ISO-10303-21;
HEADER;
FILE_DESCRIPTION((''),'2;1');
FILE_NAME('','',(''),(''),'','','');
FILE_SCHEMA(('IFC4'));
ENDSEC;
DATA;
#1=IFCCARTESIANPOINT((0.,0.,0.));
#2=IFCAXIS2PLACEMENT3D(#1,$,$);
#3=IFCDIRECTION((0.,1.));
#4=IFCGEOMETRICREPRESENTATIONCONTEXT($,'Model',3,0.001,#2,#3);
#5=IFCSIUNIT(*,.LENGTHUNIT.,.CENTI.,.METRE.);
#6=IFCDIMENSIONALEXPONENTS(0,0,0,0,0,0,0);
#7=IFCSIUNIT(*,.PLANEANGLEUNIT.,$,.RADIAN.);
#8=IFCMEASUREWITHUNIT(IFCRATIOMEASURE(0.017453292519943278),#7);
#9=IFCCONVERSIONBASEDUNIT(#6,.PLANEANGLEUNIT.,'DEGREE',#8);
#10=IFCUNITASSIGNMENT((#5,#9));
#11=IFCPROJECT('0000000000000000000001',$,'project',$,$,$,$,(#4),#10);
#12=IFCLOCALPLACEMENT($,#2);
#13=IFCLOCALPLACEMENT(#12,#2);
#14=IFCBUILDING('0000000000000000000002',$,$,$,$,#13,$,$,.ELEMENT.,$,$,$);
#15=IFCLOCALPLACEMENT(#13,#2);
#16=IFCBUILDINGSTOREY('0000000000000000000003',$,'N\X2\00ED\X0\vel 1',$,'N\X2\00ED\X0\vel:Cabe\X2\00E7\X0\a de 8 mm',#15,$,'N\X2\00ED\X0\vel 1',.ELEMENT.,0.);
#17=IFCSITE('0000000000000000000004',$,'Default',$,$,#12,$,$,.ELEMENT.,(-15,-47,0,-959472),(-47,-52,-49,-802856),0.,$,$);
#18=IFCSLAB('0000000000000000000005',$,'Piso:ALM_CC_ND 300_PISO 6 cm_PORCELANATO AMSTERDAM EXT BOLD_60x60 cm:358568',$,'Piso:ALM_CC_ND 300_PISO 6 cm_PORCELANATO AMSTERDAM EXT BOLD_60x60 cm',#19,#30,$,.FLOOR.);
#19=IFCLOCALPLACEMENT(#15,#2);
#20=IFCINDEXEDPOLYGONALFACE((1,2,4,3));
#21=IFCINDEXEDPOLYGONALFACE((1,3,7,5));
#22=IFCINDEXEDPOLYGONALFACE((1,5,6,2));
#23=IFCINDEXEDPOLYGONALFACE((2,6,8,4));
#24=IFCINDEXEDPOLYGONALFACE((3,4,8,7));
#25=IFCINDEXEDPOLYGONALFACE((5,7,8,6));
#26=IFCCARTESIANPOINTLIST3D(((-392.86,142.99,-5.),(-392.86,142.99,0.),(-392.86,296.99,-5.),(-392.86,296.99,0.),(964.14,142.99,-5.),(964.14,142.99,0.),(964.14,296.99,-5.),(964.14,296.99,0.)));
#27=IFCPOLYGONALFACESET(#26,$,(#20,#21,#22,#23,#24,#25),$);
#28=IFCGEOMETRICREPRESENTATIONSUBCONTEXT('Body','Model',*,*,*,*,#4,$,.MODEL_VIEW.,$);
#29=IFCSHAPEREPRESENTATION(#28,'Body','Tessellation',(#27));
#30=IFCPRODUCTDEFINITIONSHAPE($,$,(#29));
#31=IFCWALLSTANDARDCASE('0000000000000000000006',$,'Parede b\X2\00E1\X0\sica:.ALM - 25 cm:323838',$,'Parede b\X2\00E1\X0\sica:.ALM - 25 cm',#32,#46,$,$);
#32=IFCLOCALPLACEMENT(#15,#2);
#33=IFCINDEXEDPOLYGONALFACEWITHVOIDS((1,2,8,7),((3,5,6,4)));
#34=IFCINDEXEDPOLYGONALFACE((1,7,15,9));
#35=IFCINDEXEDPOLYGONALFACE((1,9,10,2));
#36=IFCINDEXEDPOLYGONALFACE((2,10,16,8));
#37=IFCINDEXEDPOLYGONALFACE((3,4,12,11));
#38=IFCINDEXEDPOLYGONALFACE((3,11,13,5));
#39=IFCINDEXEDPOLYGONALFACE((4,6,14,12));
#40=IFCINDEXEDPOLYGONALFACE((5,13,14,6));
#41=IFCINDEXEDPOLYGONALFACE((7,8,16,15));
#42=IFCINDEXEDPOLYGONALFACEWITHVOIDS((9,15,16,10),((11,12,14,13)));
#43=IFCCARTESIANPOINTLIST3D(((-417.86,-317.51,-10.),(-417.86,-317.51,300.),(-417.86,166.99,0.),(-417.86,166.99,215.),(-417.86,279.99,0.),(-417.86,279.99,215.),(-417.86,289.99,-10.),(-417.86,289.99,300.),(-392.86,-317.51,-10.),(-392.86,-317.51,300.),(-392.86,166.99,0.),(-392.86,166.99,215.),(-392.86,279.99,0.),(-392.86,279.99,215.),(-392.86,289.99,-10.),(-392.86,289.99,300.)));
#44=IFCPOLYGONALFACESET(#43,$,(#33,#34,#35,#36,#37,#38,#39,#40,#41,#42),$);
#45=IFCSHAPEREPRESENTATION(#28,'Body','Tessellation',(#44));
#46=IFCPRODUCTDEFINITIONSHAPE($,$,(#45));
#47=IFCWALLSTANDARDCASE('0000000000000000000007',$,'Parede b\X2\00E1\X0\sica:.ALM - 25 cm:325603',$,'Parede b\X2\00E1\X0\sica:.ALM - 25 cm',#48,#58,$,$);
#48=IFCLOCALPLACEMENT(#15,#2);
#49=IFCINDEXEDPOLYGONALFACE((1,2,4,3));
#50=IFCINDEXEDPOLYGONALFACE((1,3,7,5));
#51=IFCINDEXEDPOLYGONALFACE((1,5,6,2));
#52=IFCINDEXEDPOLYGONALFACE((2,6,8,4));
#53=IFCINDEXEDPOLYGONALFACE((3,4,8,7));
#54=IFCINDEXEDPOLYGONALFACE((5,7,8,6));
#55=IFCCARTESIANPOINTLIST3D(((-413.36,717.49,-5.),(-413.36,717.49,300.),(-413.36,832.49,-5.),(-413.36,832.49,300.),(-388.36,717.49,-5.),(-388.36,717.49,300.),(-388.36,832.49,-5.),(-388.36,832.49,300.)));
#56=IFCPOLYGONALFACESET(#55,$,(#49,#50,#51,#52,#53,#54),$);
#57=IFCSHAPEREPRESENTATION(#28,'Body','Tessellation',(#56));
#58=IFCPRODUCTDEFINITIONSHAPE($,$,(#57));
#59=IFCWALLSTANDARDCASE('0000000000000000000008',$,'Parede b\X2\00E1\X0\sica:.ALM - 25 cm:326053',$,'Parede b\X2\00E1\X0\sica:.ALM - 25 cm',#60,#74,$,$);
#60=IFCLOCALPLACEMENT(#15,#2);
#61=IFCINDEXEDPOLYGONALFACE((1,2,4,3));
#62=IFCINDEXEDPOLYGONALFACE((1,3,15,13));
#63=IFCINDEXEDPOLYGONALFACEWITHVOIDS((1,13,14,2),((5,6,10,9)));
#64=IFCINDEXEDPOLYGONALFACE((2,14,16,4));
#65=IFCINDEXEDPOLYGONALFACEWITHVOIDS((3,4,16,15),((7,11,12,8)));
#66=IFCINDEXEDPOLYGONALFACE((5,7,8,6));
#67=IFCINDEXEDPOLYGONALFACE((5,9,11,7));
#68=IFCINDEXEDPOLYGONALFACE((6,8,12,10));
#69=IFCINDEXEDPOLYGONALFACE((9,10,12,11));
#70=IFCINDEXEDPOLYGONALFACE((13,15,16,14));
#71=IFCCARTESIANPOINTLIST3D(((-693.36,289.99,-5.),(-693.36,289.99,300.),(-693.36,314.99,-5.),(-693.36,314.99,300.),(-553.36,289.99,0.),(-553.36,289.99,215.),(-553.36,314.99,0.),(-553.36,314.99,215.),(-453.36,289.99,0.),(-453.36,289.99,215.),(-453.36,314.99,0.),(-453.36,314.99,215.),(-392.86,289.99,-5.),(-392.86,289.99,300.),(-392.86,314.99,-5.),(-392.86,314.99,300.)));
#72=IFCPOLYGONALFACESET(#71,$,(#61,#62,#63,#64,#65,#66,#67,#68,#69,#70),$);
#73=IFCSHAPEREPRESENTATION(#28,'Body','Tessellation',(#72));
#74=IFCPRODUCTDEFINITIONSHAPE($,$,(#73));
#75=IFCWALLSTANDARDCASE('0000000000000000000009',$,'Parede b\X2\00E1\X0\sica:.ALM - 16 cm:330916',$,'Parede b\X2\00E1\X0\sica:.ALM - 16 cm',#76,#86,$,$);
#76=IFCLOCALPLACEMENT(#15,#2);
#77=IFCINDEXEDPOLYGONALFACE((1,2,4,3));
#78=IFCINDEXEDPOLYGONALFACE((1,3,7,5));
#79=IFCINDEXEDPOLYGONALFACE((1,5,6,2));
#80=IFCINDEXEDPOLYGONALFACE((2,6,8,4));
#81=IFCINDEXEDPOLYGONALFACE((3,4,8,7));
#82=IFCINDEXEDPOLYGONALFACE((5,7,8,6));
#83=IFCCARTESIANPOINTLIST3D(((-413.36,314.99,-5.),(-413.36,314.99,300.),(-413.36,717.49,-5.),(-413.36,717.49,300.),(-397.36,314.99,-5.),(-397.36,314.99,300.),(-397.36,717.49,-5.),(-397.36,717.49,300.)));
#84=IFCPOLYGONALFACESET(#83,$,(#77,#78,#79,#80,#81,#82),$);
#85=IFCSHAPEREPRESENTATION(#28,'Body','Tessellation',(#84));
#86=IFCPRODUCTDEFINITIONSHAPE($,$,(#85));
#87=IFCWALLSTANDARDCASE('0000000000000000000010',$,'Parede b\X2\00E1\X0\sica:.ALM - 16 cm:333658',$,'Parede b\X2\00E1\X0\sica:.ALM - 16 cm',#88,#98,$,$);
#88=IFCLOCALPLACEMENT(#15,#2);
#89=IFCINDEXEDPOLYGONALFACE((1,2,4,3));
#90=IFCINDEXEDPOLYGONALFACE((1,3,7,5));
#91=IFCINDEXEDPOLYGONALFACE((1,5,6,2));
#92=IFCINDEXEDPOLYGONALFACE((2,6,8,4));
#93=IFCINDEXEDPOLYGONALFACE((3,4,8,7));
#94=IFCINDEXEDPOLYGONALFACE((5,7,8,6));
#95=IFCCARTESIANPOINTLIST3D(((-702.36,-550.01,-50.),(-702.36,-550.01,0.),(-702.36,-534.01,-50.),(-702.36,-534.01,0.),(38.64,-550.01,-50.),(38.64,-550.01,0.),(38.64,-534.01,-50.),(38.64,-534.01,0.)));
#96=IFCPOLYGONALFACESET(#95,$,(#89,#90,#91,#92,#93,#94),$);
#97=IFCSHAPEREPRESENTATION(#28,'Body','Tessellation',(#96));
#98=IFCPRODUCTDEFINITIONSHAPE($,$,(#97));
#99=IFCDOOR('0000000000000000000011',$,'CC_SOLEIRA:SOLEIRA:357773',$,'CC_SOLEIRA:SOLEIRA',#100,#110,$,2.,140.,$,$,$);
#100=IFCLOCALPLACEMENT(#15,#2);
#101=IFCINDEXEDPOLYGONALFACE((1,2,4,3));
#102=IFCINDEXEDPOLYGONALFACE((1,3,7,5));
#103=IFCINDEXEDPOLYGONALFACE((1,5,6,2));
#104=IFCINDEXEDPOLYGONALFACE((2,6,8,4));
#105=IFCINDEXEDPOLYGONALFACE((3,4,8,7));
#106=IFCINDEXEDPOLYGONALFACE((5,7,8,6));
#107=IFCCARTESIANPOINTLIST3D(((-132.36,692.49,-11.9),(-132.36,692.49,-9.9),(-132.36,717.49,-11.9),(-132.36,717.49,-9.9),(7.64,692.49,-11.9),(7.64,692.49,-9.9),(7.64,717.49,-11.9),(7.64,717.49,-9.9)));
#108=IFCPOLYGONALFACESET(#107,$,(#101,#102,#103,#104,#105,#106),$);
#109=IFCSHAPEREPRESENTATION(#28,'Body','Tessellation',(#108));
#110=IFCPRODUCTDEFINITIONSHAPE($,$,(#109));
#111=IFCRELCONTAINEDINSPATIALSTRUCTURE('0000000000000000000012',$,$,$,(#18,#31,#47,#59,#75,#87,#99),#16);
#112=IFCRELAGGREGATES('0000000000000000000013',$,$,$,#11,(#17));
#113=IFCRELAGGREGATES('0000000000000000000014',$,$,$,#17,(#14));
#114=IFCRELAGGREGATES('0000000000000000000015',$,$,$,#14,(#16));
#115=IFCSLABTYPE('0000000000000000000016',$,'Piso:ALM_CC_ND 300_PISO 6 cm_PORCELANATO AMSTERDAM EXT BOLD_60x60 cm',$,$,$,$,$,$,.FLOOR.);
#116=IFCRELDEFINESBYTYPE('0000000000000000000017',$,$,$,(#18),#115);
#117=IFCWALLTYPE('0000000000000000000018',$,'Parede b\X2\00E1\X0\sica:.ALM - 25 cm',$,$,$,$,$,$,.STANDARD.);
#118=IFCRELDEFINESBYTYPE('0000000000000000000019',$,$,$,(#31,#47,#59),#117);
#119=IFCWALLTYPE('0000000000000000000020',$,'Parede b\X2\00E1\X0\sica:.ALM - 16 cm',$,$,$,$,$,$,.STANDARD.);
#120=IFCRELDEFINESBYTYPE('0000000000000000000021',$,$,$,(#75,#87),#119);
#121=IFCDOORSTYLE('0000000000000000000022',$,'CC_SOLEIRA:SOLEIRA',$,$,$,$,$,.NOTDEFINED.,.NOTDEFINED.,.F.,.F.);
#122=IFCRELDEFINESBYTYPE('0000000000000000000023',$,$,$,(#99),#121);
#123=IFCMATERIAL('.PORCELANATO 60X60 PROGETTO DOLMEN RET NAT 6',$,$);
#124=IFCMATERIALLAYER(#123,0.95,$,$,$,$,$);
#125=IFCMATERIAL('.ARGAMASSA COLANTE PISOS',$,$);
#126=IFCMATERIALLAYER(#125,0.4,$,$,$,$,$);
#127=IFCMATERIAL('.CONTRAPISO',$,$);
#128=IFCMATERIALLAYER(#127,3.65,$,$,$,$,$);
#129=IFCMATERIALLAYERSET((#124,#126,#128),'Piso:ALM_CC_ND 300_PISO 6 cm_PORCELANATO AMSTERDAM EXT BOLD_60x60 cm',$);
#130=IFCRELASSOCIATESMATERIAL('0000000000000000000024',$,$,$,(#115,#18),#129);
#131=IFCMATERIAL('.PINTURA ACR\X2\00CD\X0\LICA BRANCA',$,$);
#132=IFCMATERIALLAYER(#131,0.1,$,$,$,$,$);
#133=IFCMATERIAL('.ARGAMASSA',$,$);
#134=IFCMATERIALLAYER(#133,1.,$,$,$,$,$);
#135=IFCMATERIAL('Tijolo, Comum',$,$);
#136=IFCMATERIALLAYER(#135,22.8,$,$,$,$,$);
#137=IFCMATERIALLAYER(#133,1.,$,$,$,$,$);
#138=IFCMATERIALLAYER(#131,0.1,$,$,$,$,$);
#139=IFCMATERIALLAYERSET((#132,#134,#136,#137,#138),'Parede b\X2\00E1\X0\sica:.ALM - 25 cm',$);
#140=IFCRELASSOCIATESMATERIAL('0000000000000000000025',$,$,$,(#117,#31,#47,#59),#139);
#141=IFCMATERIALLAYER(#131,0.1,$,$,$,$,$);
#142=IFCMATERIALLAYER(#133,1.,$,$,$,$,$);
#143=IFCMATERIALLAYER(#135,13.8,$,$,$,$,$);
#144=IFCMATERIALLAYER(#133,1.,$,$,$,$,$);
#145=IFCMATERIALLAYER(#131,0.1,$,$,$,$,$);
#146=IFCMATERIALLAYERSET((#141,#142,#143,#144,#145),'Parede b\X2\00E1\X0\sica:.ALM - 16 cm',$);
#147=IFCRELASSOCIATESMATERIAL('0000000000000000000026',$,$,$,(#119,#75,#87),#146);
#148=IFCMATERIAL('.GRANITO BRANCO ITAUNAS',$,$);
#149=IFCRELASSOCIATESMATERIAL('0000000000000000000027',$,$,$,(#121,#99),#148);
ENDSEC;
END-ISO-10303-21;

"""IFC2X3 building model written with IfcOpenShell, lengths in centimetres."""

from ifc_helpers import new_model, entity, si_unit, converted_unit, direction, frame, frame_2d, origin, origin_2d_with_axis, place, context, subcontext, project, spatial, rectangle, extrude, source, transform, mapped, material, layer, layer_set, layer_usage, type_object, type_shapes, element, save


model = new_model("IFC2X3")

# Units and contexts
model_context = context("Model", 3, precision=0.001, world=origin(), true_north=direction((0.0, 1.0)))
body_context = subcontext(model_context, "Body", "Model", "MODEL_VIEW")
ifc_project = project(units=[si_unit("LENGTHUNIT", "METRE", prefix="CENTI"), converted_unit("PLANEANGLEUNIT", "DEGREE", entity("IfcRatioMeasure", 0.017453292519943278), si_unit("PLANEANGLEUNIT", "RADIAN"), dimensions=[0, 0, 0, 0, 0, 0, 0])], contexts=[model_context])

# Site, building, storey
site_placement = place(None, origin())
site = spatial("IfcSite", under=ifc_project, at=site_placement, Name="Default", CompositionType="ELEMENT", RefLatitude=(-15, -47, 0, -959472), RefLongitude=(-47, -52, -49, -802856), RefElevation=0.0)
building_placement = place(site_placement, origin())
building = spatial("IfcBuilding", under=site, at=building_placement, CompositionType="ELEMENT")
storey_placement = place(building_placement, origin())
storey = spatial("IfcBuildingStorey", under=building, at=storey_placement, Name="Nível 1", ObjectType="Nível:Cabeça de 8 mm", LongName="Nível 1", CompositionType="ELEMENT", Elevation=0.0)

# Slab
ifc_material_1 = material(Name=".PORCELANATO 60X60 PROGETTO DOLMEN RET NAT 6")
ifc_layer_1 = layer(ifc_material_1, 0.95)
ifc_material_2 = material(Name=".ARGAMASSA COLANTE PISOS")
ifc_layer_2 = layer(ifc_material_2, 0.4)
ifc_material_3 = material(Name=".CONTRAPISO")
ifc_layer_3 = layer(ifc_material_3, 3.65)
ifc_layer_set_1 = layer_set([ifc_layer_1, ifc_layer_2, ifc_layer_3], Name="Piso:ALM_CC_ND 300_PISO 6 cm_PORCELANATO AMSTERDAM EXT BOLD_60x60 cm")
ifc_layer_usage_1 = layer_usage(ifc_layer_set_1, "AXIS3", "POSITIVE", 0.0)
slab_type_1 = type_object("IfcSlabType", Name="Piso:ALM_CC_ND 300_PISO 6 cm_PORCELANATO AMSTERDAM EXT BOLD_60x60 cm", PredefinedType="FLOOR", material=ifc_layer_set_1)
slab_1_placement = place(storey_placement, origin())
element("IfcSlab", 1, at=slab_1_placement, inside=storey, type_object=slab_type_1, material=ifc_layer_usage_1, Name="Piso:ALM_CC_ND 300_PISO 6 cm_PORCELANATO AMSTERDAM EXT BOLD_60x60 cm:358568", ObjectType="Piso:ALM_CC_ND 300_PISO 6 cm_PORCELANATO AMSTERDAM EXT BOLD_60x60 cm", PredefinedType="FLOOR", context=body_context, shape_type="SweptSolid", body=[
    extrude(rectangle(XDim=154.0, YDim=1357.0, at=frame_2d((0.0, 0.0), x_axis=(1.0, 0.0))), frame((285.64, 219.99, 0.0), z_axis=(0.0, 0.0, -1.0), x_axis=(0.0, 1.0, 0.0)), (0.0, 0.0, 1.0), 5.0),
])

# Wall, opening
ifc_material_4 = material(Name=".PINTURA ACRÍLICA BRANCA")
ifc_layer_4 = layer(ifc_material_4, 0.1)
ifc_material_5 = material(Name=".ARGAMASSA")
ifc_layer_5 = layer(ifc_material_5, 1.0)
ifc_material_6 = material(Name="Tijolo, Comum")
ifc_layer_6 = layer(ifc_material_6, 22.8)
ifc_layer_7 = layer(ifc_material_5, 1.0)
ifc_layer_8 = layer(ifc_material_4, 0.1)
ifc_layer_set_2 = layer_set([ifc_layer_4, ifc_layer_5, ifc_layer_6, ifc_layer_7, ifc_layer_8], Name="Parede básica:.ALM - 25 cm")
ifc_layer_usage_2 = layer_usage(ifc_layer_set_2, "AXIS2", "NEGATIVE", 12.5)
wall_type_1 = type_object("IfcWallType", Name="Parede básica:.ALM - 25 cm", PredefinedType="STANDARD", material=ifc_layer_set_2)
wall_1_placement = place(storey_placement, frame((-405.36, -317.51, -10.0), z_axis=(0.0, 0.0, 1.0), x_axis=(0.0, 1.0, 0.0)))
wall_1 = element("IfcWallStandardCase", 2, at=wall_1_placement, inside=storey, type_object=wall_type_1, material=ifc_layer_usage_2, Name="Parede básica:.ALM - 25 cm:323838", ObjectType="Parede básica:.ALM - 25 cm", context=body_context, shape_type="SweptSolid", body=[
    extrude(rectangle(XDim=607.5, YDim=25.0, at=frame_2d((303.75, 0.0), x_axis=(-1.0, 0.0))), origin(), (0.0, 0.0, 1.0), 310.0),
])
opening_1_placement = place(wall_1_placement, frame((484.5, -12.5, 10.0)))
element("IfcOpeningElement", 3, at=opening_1_placement, cuts=wall_1, ObjectType="Opening", context=body_context, shape_type="SweptSolid", body=[
    extrude(rectangle(XDim=215.0, YDim=113.0, at=frame_2d((107.5, 56.5), x_axis=(1.0, 0.0))), frame((0.0, 0.0, 0.0), z_axis=(0.0, 1.0, 0.0), x_axis=(0.0, 0.0, 1.0)), (0.0, 0.0, 1.0), 25.0),
])

# Wall
wall_2_placement = place(storey_placement, frame((-400.86, 717.49, -5.0), z_axis=(0.0, 0.0, 1.0), x_axis=(0.0, 1.0, 0.0)))
element("IfcWallStandardCase", 4, at=wall_2_placement, inside=storey, type_object=wall_type_1, material=ifc_layer_usage_2, Name="Parede básica:.ALM - 25 cm:325603", ObjectType="Parede básica:.ALM - 25 cm", context=body_context, shape_type="SweptSolid", body=[
    extrude(rectangle(XDim=115.0, YDim=25.0, at=frame_2d((57.5, 0.0), x_axis=(-1.0, 0.0))), origin(), (0.0, 0.0, 1.0), 305.0),
])

# Wall, opening
wall_3_placement = place(storey_placement, frame((-392.86, 302.49, -5.0), z_axis=(0.0, 0.0, 1.0), x_axis=(-1.0, 0.0, 0.0)))
wall_3 = element("IfcWallStandardCase", 5, at=wall_3_placement, inside=storey, type_object=wall_type_1, material=ifc_layer_usage_2, Name="Parede básica:.ALM - 25 cm:326053", ObjectType="Parede básica:.ALM - 25 cm", context=body_context, shape_type="SweptSolid", body=[
    extrude(rectangle(XDim=300.5, YDim=25.0, at=frame_2d((150.25, 0.0), x_axis=(-1.0, 0.0))), origin(), (0.0, 0.0, 1.0), 305.0),
])
opening_2_placement = place(wall_3_placement, frame((60.5, -12.5, 5.0)))
element("IfcOpeningElement", 6, at=opening_2_placement, cuts=wall_3, ObjectType="Opening", context=body_context, shape_type="SweptSolid", body=[
    extrude(rectangle(XDim=215.0, YDim=100.0, at=frame_2d((107.5, 50.0), x_axis=(1.0, 0.0))), frame((0.0, 0.0, 0.0), z_axis=(0.0, 1.0, 0.0), x_axis=(0.0, 0.0, 1.0)), (0.0, 0.0, 1.0), 25.0),
])

# Walls
ifc_layer_9 = layer(ifc_material_4, 0.1)
ifc_layer_10 = layer(ifc_material_5, 1.0)
ifc_layer_11 = layer(ifc_material_6, 13.8)
ifc_layer_12 = layer(ifc_material_5, 1.0)
ifc_layer_13 = layer(ifc_material_4, 0.1)
ifc_layer_set_3 = layer_set([ifc_layer_9, ifc_layer_10, ifc_layer_11, ifc_layer_12, ifc_layer_13], Name="Parede básica:.ALM - 16 cm")
ifc_layer_usage_3 = layer_usage(ifc_layer_set_3, "AXIS2", "NEGATIVE", 8.0)
wall_type_2 = type_object("IfcWallType", Name="Parede básica:.ALM - 16 cm", PredefinedType="STANDARD", material=ifc_layer_set_3)
wall_4_placement = place(storey_placement, frame((-405.36, 314.99, -5.0), z_axis=(0.0, 0.0, 1.0), x_axis=(0.0, 1.0, 0.0)))
element("IfcWallStandardCase", 7, at=wall_4_placement, inside=storey, type_object=wall_type_2, material=ifc_layer_usage_3, Name="Parede básica:.ALM - 16 cm:330916", ObjectType="Parede básica:.ALM - 16 cm", context=body_context, shape_type="SweptSolid", body=[
    extrude(rectangle(XDim=402.5, YDim=16.0, at=frame_2d((201.25, 0.0), x_axis=(-1.0, 0.0))), origin(), (0.0, 0.0, 1.0), 305.0),
])
ifc_layer_usage_4 = layer_usage(ifc_layer_set_3, "AXIS2", "POSITIVE", -8.0)
wall_5_placement = place(storey_placement, frame((-702.36, -542.01, -50.0)))
element("IfcWallStandardCase", 8, at=wall_5_placement, inside=storey, type_object=wall_type_2, material=ifc_layer_usage_4, Name="Parede básica:.ALM - 16 cm:333658", ObjectType="Parede básica:.ALM - 16 cm", context=body_context, shape_type="SweptSolid", body=[
    extrude(rectangle(XDim=741.0, YDim=16.0, at=frame_2d((370.5, 0.0), x_axis=(-1.0, 0.0))), origin(), (0.0, 0.0, 1.0), 50.0),
])

# Door
ifc_material_7 = material(Name=".GRANITO BRANCO ITAUNAS")
door_style = type_object("IfcDoorStyle", Name="CC_SOLEIRA:SOLEIRA", ConstructionType="NOTDEFINED", OperationType="NOTDEFINED", ParameterTakesPrecedence=False, Sizeable=False, material=ifc_material_7)
shared_shape = source(origin(), body_context, "Body", "SweptSolid", [
    extrude(rectangle(XDim=140.0, YDim=25.0, at=origin_2d_with_axis()), frame((70.0, 12.5, 0.0), z_axis=(0.0, 0.0, 1.0), x_axis=(-1.0, 0.0, 0.0)), (0.0, 0.0, 1.0), 2.0),
])
type_shapes(door_style, [shared_shape])
door_placement = place(storey_placement, frame((-132.36, 692.49, -11.9)))
element("IfcDoor", 9, at=door_placement, inside=storey, type_object=door_style, material=ifc_material_7, Name="CC_SOLEIRA:SOLEIRA:357773", ObjectType="CC_SOLEIRA:SOLEIRA", OverallHeight=2.0, OverallWidth=140.0, context=body_context, shape_type="MappedRepresentation", body=[
    mapped(shared_shape, transform((0.0, 0.0, 0.0), scale=1.0)),
])

save(model, "model.ifc")
